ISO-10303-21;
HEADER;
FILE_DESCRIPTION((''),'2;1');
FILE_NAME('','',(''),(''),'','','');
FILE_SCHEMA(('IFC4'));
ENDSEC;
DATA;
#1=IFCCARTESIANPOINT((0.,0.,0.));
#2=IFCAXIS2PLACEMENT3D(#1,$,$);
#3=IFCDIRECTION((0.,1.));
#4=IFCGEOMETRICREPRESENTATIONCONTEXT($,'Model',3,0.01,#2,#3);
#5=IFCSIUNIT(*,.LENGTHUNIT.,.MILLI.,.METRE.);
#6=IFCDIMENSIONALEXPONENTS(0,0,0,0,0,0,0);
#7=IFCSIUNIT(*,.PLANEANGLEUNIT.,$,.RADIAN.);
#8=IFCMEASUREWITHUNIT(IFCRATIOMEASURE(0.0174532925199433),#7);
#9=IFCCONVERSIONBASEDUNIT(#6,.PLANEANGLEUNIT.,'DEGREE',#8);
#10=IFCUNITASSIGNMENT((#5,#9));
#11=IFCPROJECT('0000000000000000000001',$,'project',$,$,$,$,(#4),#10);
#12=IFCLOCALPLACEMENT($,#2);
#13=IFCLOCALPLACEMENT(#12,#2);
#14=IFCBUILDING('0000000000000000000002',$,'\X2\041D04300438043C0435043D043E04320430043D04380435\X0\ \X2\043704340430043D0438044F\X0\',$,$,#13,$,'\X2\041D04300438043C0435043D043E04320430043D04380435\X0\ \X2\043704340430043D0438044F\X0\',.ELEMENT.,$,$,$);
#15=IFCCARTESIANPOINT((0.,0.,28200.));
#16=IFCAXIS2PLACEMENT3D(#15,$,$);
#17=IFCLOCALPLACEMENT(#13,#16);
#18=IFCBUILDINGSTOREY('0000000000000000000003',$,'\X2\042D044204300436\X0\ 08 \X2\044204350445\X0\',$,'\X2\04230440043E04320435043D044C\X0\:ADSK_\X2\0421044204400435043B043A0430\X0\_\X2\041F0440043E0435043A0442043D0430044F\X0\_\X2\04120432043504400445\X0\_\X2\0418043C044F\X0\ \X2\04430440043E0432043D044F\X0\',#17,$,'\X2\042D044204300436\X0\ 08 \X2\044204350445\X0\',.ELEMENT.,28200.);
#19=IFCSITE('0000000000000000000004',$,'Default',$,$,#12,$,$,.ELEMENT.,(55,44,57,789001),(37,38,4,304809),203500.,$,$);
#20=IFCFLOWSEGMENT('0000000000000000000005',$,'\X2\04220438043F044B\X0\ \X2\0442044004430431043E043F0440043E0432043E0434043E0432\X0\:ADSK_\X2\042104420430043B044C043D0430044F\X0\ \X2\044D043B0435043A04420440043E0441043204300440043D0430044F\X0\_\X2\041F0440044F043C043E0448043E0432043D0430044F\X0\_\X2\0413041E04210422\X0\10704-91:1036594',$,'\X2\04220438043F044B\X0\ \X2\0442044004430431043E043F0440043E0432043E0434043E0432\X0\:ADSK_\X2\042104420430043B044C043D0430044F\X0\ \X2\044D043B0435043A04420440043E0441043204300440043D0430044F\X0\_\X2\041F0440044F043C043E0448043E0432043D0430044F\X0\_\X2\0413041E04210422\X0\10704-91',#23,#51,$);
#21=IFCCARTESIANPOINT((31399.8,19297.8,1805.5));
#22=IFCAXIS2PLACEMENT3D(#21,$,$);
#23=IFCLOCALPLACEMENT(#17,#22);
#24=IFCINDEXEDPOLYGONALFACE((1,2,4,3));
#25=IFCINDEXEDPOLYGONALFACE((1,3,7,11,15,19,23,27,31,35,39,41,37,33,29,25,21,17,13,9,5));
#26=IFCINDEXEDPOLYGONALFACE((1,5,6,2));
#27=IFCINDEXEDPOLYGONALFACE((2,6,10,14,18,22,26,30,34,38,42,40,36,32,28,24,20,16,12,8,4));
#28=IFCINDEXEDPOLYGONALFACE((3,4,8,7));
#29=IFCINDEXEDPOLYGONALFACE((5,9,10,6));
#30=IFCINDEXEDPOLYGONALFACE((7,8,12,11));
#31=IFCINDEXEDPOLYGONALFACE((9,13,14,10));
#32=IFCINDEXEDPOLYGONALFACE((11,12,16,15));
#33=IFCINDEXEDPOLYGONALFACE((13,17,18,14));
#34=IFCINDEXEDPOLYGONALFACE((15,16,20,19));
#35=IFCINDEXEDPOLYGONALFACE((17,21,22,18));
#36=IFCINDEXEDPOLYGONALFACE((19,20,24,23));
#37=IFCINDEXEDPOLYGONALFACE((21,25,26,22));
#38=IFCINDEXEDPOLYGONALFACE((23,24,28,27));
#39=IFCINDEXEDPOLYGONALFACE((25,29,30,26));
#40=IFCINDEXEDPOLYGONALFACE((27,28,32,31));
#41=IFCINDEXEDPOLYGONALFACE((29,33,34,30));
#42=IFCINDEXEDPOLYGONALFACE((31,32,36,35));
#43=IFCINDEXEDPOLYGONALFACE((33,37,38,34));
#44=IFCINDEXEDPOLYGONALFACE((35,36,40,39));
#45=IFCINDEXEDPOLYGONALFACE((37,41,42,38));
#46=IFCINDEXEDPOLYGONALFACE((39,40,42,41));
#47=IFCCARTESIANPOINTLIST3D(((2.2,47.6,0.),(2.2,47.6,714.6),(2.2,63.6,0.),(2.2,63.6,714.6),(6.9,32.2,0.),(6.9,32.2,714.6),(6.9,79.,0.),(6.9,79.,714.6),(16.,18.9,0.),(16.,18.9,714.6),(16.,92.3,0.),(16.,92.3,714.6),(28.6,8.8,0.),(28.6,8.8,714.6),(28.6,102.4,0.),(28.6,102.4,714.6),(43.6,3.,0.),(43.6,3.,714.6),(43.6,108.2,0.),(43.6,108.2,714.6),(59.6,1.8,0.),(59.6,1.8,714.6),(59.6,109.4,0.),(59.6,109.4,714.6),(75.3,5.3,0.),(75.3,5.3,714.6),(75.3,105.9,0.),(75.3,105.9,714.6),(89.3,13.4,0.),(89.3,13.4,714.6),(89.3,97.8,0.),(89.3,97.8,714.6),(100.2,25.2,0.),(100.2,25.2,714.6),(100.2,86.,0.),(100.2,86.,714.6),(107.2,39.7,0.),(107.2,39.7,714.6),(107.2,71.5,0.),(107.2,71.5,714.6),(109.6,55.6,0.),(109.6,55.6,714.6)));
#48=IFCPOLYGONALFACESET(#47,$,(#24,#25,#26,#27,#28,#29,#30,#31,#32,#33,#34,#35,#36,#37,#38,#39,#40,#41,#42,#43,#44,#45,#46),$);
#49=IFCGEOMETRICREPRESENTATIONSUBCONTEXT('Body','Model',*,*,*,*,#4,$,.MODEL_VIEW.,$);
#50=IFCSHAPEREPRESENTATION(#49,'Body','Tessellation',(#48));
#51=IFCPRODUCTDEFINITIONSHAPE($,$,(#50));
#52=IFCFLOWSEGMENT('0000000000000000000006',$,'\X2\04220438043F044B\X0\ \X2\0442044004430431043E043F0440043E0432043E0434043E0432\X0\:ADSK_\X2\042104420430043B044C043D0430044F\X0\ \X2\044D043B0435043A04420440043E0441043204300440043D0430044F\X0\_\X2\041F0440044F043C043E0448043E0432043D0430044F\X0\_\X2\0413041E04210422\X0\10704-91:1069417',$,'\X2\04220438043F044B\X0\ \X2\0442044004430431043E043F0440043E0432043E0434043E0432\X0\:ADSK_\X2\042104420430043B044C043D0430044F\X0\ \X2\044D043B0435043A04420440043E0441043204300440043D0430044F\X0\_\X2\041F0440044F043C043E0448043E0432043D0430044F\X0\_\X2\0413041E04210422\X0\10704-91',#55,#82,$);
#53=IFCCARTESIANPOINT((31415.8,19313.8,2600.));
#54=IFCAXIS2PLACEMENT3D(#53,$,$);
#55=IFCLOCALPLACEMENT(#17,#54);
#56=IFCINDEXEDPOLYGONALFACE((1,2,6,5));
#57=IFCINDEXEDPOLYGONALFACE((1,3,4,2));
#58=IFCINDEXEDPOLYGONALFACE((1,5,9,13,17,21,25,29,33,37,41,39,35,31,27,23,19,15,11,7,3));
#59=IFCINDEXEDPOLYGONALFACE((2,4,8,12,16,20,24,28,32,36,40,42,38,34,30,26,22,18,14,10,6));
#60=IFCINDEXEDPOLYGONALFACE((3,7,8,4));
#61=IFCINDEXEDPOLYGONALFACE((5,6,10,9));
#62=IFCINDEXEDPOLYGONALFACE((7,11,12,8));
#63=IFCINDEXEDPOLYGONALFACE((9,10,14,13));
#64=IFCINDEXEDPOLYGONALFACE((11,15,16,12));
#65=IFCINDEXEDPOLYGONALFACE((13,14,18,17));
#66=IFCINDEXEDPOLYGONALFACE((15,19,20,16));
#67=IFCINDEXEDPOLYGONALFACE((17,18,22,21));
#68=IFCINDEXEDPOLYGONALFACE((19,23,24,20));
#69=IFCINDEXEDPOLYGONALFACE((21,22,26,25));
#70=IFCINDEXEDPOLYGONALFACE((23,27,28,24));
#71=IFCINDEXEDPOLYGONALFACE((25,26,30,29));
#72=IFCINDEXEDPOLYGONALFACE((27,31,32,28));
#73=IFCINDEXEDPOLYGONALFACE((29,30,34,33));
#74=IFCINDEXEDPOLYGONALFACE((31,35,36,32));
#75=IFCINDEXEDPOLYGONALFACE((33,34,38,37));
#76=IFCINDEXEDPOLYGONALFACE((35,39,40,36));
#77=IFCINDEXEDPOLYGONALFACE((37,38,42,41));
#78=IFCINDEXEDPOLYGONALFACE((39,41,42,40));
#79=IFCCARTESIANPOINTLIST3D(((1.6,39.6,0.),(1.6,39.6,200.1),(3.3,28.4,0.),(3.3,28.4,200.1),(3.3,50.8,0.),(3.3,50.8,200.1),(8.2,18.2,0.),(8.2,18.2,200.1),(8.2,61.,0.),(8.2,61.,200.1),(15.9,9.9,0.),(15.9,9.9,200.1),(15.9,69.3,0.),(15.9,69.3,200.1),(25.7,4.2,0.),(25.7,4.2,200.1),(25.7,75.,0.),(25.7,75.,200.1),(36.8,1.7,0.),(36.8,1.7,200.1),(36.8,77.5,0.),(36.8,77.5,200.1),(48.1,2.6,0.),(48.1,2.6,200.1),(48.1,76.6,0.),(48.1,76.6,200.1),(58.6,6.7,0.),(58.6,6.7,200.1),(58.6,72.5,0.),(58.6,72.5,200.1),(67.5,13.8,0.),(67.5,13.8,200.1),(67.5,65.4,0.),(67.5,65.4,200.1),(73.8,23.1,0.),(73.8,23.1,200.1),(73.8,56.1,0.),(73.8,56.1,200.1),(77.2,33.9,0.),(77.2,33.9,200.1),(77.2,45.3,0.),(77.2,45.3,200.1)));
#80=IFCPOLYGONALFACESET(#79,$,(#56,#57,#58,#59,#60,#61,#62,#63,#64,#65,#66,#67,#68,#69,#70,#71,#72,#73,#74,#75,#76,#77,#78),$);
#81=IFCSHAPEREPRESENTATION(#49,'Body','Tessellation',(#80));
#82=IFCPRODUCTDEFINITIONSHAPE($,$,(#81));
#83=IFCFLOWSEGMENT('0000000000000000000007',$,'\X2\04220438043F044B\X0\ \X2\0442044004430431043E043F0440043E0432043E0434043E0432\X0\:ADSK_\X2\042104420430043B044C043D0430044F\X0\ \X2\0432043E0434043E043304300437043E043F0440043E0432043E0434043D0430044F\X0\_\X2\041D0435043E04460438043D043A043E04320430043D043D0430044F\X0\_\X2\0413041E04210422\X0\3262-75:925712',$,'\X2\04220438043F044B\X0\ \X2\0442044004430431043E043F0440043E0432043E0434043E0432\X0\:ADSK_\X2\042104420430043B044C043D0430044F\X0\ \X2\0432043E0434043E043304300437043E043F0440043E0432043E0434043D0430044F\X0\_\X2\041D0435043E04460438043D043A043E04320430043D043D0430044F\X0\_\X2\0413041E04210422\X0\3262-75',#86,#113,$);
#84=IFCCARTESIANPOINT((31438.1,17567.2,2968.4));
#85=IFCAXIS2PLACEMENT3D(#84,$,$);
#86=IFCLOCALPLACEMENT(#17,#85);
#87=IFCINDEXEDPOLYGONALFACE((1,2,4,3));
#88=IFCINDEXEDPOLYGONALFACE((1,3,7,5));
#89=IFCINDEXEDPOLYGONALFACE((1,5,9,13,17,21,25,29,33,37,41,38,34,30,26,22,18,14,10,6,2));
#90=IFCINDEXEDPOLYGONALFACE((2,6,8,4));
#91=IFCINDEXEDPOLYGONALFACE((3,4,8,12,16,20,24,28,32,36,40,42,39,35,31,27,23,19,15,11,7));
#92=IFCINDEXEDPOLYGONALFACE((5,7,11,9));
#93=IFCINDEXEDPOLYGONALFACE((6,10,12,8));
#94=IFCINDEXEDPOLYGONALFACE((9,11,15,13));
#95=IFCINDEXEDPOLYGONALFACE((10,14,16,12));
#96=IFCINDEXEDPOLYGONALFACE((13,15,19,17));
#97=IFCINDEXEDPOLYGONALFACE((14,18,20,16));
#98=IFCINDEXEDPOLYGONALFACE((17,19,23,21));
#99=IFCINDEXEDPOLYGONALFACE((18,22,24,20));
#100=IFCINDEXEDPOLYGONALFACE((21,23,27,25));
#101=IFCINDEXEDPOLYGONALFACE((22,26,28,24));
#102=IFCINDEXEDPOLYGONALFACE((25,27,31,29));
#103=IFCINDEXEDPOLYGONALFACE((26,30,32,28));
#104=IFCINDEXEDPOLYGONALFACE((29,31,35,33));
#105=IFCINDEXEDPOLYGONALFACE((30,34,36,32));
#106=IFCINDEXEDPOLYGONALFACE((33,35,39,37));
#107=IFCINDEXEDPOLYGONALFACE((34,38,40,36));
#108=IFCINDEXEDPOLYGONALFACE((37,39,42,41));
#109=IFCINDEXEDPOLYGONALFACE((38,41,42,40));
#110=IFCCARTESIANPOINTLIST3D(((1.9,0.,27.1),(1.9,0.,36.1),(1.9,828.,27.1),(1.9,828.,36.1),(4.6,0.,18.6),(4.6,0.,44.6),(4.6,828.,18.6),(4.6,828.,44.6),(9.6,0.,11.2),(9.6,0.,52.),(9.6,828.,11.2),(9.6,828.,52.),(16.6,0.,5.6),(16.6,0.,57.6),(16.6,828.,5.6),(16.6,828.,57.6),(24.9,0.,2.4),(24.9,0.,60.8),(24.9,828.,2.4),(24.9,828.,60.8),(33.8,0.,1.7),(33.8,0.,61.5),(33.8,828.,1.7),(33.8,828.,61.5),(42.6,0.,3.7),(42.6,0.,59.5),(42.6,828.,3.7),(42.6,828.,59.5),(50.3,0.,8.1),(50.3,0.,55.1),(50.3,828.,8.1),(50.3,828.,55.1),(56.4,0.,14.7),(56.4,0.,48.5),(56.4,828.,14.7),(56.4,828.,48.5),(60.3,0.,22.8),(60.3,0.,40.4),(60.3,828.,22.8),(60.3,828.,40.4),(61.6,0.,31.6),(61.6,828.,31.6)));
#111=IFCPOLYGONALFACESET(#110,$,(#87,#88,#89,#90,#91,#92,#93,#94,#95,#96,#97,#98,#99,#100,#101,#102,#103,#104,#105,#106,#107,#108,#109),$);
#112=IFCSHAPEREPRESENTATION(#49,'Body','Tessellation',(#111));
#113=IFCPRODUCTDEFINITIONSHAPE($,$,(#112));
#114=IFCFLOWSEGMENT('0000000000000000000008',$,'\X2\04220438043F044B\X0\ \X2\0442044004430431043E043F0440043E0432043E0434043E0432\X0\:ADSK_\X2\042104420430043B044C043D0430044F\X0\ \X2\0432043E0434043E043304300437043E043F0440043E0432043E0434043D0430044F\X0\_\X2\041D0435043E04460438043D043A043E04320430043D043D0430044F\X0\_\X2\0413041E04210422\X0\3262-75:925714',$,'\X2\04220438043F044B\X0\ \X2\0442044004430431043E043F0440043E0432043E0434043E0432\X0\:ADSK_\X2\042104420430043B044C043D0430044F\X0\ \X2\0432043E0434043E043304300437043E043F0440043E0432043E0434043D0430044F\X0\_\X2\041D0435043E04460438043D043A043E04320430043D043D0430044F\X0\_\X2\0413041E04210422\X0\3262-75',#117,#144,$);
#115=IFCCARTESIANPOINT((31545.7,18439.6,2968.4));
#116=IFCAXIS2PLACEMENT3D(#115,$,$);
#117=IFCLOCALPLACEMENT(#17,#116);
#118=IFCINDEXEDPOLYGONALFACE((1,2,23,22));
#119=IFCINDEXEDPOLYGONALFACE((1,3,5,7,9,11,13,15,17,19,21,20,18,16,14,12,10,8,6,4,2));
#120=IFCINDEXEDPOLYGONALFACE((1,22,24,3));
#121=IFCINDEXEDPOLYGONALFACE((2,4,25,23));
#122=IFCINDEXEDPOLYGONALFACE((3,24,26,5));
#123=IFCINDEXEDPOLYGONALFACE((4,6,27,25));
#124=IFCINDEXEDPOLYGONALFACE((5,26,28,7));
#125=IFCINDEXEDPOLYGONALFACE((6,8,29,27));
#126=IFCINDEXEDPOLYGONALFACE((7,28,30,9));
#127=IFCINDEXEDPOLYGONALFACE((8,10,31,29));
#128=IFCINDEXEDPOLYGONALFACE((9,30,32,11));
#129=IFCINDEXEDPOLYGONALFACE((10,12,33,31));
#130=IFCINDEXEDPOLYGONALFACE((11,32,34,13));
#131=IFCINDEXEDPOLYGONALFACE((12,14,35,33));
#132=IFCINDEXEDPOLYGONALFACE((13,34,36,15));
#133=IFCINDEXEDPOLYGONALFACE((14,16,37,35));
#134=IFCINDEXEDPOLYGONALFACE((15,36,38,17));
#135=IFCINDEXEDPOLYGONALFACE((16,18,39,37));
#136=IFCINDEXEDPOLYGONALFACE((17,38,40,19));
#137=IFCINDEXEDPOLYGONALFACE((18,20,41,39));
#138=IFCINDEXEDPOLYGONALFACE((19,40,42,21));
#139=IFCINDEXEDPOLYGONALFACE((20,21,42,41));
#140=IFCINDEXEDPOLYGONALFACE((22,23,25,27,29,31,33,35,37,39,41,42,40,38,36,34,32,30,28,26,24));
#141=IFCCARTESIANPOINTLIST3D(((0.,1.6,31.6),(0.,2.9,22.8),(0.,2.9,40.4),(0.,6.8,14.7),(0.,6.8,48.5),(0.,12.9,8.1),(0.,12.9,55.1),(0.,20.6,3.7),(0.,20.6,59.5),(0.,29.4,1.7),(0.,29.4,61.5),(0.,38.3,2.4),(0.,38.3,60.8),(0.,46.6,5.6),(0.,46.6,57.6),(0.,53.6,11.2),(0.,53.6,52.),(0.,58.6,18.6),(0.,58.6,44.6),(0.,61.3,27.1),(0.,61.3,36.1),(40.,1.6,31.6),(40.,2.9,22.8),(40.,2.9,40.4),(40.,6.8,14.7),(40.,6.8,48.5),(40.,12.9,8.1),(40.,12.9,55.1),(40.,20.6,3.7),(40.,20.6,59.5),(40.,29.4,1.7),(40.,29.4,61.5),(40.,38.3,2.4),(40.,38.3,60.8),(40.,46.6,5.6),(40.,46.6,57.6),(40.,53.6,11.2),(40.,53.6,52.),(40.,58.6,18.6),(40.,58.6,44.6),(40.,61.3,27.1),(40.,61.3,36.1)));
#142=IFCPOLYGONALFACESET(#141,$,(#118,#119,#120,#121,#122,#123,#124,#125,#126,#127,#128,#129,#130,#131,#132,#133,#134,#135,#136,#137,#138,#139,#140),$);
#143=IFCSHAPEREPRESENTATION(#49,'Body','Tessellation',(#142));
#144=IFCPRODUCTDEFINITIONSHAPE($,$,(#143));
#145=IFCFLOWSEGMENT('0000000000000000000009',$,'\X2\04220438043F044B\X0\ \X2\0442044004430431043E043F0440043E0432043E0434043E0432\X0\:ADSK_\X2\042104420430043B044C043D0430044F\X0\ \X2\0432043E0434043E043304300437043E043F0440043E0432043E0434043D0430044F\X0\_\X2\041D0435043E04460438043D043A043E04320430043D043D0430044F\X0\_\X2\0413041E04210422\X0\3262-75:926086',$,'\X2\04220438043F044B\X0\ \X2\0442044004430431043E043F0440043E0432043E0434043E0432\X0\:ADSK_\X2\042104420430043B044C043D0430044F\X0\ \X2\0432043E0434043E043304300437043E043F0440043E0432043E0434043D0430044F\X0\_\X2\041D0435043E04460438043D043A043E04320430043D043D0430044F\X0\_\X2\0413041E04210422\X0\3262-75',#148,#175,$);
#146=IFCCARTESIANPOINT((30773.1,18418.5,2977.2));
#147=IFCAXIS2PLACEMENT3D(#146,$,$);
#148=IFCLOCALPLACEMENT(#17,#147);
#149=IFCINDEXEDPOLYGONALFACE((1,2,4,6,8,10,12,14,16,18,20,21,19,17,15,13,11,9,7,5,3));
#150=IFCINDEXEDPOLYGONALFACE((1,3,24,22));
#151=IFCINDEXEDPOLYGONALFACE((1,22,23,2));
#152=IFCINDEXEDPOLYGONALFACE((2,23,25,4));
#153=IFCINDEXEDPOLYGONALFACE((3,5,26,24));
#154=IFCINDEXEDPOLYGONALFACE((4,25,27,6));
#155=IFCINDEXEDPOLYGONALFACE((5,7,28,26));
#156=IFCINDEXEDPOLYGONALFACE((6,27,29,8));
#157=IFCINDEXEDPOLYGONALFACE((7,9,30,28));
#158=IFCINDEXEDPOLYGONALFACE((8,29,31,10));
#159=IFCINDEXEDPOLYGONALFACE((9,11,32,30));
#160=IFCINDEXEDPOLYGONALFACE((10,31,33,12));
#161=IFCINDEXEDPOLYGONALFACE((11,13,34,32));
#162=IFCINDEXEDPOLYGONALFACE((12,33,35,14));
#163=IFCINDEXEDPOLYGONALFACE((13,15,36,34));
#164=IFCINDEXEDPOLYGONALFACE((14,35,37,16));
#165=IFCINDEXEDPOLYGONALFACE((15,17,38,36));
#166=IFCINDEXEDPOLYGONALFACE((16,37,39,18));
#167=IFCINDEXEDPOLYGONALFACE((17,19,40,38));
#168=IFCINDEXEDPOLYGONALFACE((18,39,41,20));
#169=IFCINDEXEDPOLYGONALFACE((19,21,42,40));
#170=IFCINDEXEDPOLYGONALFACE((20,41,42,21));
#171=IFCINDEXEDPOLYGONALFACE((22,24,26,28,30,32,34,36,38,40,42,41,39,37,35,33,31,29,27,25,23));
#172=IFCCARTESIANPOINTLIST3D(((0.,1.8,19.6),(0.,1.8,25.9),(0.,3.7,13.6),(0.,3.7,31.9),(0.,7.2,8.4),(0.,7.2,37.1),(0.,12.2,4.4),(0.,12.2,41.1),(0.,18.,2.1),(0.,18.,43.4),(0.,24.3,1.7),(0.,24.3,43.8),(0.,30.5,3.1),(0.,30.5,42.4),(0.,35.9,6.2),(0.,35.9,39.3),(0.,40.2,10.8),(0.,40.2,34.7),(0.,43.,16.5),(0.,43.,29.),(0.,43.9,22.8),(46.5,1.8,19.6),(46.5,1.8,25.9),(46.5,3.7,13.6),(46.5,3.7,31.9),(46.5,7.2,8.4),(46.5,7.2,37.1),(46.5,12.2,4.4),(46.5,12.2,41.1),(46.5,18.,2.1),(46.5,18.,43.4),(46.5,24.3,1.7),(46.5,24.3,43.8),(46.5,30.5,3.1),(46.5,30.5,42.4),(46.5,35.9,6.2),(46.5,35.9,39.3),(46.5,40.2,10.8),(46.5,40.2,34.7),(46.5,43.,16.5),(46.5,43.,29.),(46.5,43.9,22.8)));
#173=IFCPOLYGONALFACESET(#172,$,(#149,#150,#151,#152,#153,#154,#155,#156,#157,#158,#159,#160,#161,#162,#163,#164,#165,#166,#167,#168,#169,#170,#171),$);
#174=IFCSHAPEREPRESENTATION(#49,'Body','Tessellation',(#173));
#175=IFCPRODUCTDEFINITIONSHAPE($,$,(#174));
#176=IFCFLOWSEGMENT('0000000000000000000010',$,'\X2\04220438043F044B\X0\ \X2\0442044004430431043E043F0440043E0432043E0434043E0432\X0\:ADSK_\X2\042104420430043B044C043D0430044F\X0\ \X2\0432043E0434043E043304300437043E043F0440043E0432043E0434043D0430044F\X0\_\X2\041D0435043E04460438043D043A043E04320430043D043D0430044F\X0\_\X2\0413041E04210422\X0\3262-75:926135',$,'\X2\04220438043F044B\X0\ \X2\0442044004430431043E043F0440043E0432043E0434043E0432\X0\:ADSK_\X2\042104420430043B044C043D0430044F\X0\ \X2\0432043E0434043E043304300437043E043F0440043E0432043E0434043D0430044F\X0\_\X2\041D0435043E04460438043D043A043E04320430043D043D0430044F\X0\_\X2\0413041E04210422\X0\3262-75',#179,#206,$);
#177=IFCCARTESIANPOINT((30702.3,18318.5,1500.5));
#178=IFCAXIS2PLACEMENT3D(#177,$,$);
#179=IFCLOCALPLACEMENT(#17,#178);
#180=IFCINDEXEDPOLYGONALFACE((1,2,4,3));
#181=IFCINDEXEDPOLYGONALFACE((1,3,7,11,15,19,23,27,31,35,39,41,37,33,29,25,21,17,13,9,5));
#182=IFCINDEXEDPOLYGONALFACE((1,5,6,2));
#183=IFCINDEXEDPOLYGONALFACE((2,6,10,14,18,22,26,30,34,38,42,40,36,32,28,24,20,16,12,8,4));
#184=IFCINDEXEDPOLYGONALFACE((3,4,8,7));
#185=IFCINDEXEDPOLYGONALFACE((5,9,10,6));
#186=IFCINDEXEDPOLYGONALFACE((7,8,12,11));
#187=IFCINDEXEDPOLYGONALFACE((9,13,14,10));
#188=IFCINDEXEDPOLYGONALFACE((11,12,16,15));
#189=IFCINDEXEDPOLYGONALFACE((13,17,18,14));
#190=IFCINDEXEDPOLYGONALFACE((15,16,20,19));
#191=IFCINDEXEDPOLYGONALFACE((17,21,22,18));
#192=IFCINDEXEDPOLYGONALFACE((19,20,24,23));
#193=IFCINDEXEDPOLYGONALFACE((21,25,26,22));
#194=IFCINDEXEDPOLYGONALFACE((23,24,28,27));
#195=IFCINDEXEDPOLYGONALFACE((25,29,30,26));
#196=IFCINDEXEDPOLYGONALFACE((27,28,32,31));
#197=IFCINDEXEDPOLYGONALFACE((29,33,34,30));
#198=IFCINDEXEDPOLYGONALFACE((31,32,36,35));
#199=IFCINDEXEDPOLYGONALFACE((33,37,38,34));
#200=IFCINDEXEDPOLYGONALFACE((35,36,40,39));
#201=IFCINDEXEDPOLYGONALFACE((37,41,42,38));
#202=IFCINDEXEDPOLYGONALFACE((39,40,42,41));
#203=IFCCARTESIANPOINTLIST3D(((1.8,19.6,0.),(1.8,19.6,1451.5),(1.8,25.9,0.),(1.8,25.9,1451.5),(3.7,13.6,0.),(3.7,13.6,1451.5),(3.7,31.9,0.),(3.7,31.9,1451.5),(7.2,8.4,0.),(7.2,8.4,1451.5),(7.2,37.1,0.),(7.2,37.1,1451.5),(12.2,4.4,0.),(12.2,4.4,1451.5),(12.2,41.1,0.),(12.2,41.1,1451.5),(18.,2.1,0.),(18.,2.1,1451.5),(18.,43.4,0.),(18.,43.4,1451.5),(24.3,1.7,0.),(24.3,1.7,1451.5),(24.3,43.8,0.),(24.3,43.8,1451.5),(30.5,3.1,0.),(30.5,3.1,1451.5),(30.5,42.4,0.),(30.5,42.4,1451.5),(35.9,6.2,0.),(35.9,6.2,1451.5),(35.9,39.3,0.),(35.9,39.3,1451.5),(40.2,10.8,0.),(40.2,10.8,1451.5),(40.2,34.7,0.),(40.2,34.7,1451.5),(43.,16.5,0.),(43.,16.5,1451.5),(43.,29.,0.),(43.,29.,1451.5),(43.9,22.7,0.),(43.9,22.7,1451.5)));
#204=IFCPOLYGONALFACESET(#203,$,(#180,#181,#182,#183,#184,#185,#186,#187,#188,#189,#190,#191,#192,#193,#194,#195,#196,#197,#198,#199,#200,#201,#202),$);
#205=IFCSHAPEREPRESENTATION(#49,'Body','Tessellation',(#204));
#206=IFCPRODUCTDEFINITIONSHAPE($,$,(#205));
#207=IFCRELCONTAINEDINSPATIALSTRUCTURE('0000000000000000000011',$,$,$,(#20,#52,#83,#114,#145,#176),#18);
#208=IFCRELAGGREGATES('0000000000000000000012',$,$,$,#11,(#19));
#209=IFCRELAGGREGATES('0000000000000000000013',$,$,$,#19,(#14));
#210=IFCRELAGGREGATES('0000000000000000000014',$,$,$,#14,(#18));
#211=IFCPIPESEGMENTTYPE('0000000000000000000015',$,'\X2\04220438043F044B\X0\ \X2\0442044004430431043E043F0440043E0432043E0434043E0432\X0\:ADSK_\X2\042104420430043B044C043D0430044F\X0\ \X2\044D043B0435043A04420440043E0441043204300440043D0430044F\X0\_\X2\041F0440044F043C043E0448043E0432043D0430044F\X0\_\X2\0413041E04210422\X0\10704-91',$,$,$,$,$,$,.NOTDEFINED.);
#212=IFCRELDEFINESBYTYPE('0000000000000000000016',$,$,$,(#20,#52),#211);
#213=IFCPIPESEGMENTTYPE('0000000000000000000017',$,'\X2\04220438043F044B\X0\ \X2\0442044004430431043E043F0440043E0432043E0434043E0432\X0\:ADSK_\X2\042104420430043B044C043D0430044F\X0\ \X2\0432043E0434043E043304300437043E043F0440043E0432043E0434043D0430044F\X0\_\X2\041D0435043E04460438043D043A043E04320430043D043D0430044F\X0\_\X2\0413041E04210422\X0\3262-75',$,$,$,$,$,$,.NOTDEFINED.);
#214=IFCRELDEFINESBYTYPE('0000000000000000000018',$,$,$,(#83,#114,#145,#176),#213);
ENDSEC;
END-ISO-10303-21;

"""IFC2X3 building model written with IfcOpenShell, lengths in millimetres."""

from ifc_helpers import new_model, entity, si_unit, converted_unit, direction, frame, origin, origin_2d_with_axis, place, context, subcontext, project, spatial, circle, extrude, type_object, element, save


model = new_model("IFC2X3")

# Units and contexts
model_context = context("Model", 3, precision=0.01, world=origin(), true_north=direction((0.0, 1.0)))
body_context = subcontext(model_context, "Body", "Model", "MODEL_VIEW")
ifc_project = project(units=[si_unit("LENGTHUNIT", "METRE", prefix="MILLI"), converted_unit("PLANEANGLEUNIT", "DEGREE", entity("IfcRatioMeasure", 0.0174532925199433), si_unit("PLANEANGLEUNIT", "RADIAN"), dimensions=[0, 0, 0, 0, 0, 0, 0])], contexts=[model_context])

# Site, building, storey
site_placement = place(None, origin())
site = spatial("IfcSite", under=ifc_project, at=site_placement, Name="Default", CompositionType="ELEMENT", RefLatitude=(55, 44, 57, 789001), RefLongitude=(37, 38, 4, 304809), RefElevation=203500.0)
building_placement = place(site_placement, origin())
building = spatial("IfcBuilding", under=site, at=building_placement, Name="Наименование здания", LongName="Наименование здания", CompositionType="ELEMENT")
storey_placement = place(building_placement, frame((0.0, 0.0, 28200.0)))
storey = spatial("IfcBuildingStorey", under=building, at=storey_placement, Name="Этаж 08 тех", ObjectType="Уровень:ADSK_Стрелка_Проектная_Вверх_Имя уровня", LongName="Этаж 08 тех", CompositionType="ELEMENT", Elevation=28200.0)

# Flow segments
pipe_segment_type_1 = type_object("IfcPipeSegmentType", Name="Типы трубопроводов:ADSK_Стальная электросварная_Прямошовная_ГОСТ10704-91", PredefinedType="NOTDEFINED")
flow_segment_1_placement = place(storey_placement, frame((31399.8, 19297.8, 1805.5)))
element("IfcFlowSegment", 1, at=flow_segment_1_placement, inside=storey, type_object=pipe_segment_type_1, Name="Типы трубопроводов:ADSK_Стальная электросварная_Прямошовная_ГОСТ10704-91:1036594", ObjectType="Типы трубопроводов:ADSK_Стальная электросварная_Прямошовная_ГОСТ10704-91", context=body_context, shape_type="SweptSolid", body=[
    extrude(circle(Radius=54.0, at=origin_2d_with_axis()), frame((55.6, 55.6, 0.0)), (0.0, 0.0, 1.0), 714.6),
])
flow_segment_2_placement = place(storey_placement, frame((31415.8, 19313.8, 2600.0)))
element("IfcFlowSegment", 2, at=flow_segment_2_placement, inside=storey, type_object=pipe_segment_type_1, Name="Типы трубопроводов:ADSK_Стальная электросварная_Прямошовная_ГОСТ10704-91:1069417", ObjectType="Типы трубопроводов:ADSK_Стальная электросварная_Прямошовная_ГОСТ10704-91", context=body_context, shape_type="SweptSolid", body=[
    extrude(circle(Radius=38.0, at=origin_2d_with_axis()), frame((39.6, 39.6, 0.0), z_axis=(0.0, 0.0, 1.0), x_axis=(-1.0, 0.0, 0.0)), (0.0, 0.0, 1.0), 200.1),
])
pipe_segment_type_2 = type_object("IfcPipeSegmentType", Name="Типы трубопроводов:ADSK_Стальная водогазопроводная_Неоцинкованная_ГОСТ3262-75", PredefinedType="NOTDEFINED")
flow_segment_3_placement = place(storey_placement, frame((31438.1, 17567.2, 2968.4)))
element("IfcFlowSegment", 3, at=flow_segment_3_placement, inside=storey, type_object=pipe_segment_type_2, Name="Типы трубопроводов:ADSK_Стальная водогазопроводная_Неоцинкованная_ГОСТ3262-75:925712", ObjectType="Типы трубопроводов:ADSK_Стальная водогазопроводная_Неоцинкованная_ГОСТ3262-75", context=body_context, shape_type="SweptSolid", body=[
    extrude(circle(Radius=30.0, at=origin_2d_with_axis()), frame((31.6, 0.0, 31.6), z_axis=(0.0, 1.0, 0.0), x_axis=(1.0, 0.0, 0.0)), (0.0, 0.0, 1.0), 828.0),
])
flow_segment_4_placement = place(storey_placement, frame((31545.7, 18439.6, 2968.4)))
element("IfcFlowSegment", 4, at=flow_segment_4_placement, inside=storey, type_object=pipe_segment_type_2, Name="Типы трубопроводов:ADSK_Стальная водогазопроводная_Неоцинкованная_ГОСТ3262-75:925714", ObjectType="Типы трубопроводов:ADSK_Стальная водогазопроводная_Неоцинкованная_ГОСТ3262-75", context=body_context, shape_type="SweptSolid", body=[
    extrude(circle(Radius=30.0, at=origin_2d_with_axis()), frame((0.0, 31.6, 31.6), z_axis=(1.0, 0.0, 0.0), x_axis=(0.0, -1.0, 0.0)), (0.0, 0.0, 1.0), 40.0),
])
flow_segment_5_placement = place(storey_placement, frame((30773.1, 18418.5, 2977.2)))
element("IfcFlowSegment", 5, at=flow_segment_5_placement, inside=storey, type_object=pipe_segment_type_2, Name="Типы трубопроводов:ADSK_Стальная водогазопроводная_Неоцинкованная_ГОСТ3262-75:926086", ObjectType="Типы трубопроводов:ADSK_Стальная водогазопроводная_Неоцинкованная_ГОСТ3262-75", context=body_context, shape_type="SweptSolid", body=[
    extrude(circle(Radius=21.1, at=origin_2d_with_axis()), frame((0.0, 22.8, 22.8), z_axis=(1.0, 0.0, 0.0), x_axis=(0.0, 1.0, 0.0)), (0.0, 0.0, 1.0), 46.5),
])
flow_segment_6_placement = place(storey_placement, frame((30702.3, 18318.5, 1500.5)))
element("IfcFlowSegment", 6, at=flow_segment_6_placement, inside=storey, type_object=pipe_segment_type_2, Name="Типы трубопроводов:ADSK_Стальная водогазопроводная_Неоцинкованная_ГОСТ3262-75:926135", ObjectType="Типы трубопроводов:ADSK_Стальная водогазопроводная_Неоцинкованная_ГОСТ3262-75", context=body_context, shape_type="SweptSolid", body=[
    extrude(circle(Radius=21.1, at=origin_2d_with_axis()), frame((22.8, 22.8, 0.0)), (0.0, 0.0, 1.0), 1451.5),
])

save(model, "model.ifc")
